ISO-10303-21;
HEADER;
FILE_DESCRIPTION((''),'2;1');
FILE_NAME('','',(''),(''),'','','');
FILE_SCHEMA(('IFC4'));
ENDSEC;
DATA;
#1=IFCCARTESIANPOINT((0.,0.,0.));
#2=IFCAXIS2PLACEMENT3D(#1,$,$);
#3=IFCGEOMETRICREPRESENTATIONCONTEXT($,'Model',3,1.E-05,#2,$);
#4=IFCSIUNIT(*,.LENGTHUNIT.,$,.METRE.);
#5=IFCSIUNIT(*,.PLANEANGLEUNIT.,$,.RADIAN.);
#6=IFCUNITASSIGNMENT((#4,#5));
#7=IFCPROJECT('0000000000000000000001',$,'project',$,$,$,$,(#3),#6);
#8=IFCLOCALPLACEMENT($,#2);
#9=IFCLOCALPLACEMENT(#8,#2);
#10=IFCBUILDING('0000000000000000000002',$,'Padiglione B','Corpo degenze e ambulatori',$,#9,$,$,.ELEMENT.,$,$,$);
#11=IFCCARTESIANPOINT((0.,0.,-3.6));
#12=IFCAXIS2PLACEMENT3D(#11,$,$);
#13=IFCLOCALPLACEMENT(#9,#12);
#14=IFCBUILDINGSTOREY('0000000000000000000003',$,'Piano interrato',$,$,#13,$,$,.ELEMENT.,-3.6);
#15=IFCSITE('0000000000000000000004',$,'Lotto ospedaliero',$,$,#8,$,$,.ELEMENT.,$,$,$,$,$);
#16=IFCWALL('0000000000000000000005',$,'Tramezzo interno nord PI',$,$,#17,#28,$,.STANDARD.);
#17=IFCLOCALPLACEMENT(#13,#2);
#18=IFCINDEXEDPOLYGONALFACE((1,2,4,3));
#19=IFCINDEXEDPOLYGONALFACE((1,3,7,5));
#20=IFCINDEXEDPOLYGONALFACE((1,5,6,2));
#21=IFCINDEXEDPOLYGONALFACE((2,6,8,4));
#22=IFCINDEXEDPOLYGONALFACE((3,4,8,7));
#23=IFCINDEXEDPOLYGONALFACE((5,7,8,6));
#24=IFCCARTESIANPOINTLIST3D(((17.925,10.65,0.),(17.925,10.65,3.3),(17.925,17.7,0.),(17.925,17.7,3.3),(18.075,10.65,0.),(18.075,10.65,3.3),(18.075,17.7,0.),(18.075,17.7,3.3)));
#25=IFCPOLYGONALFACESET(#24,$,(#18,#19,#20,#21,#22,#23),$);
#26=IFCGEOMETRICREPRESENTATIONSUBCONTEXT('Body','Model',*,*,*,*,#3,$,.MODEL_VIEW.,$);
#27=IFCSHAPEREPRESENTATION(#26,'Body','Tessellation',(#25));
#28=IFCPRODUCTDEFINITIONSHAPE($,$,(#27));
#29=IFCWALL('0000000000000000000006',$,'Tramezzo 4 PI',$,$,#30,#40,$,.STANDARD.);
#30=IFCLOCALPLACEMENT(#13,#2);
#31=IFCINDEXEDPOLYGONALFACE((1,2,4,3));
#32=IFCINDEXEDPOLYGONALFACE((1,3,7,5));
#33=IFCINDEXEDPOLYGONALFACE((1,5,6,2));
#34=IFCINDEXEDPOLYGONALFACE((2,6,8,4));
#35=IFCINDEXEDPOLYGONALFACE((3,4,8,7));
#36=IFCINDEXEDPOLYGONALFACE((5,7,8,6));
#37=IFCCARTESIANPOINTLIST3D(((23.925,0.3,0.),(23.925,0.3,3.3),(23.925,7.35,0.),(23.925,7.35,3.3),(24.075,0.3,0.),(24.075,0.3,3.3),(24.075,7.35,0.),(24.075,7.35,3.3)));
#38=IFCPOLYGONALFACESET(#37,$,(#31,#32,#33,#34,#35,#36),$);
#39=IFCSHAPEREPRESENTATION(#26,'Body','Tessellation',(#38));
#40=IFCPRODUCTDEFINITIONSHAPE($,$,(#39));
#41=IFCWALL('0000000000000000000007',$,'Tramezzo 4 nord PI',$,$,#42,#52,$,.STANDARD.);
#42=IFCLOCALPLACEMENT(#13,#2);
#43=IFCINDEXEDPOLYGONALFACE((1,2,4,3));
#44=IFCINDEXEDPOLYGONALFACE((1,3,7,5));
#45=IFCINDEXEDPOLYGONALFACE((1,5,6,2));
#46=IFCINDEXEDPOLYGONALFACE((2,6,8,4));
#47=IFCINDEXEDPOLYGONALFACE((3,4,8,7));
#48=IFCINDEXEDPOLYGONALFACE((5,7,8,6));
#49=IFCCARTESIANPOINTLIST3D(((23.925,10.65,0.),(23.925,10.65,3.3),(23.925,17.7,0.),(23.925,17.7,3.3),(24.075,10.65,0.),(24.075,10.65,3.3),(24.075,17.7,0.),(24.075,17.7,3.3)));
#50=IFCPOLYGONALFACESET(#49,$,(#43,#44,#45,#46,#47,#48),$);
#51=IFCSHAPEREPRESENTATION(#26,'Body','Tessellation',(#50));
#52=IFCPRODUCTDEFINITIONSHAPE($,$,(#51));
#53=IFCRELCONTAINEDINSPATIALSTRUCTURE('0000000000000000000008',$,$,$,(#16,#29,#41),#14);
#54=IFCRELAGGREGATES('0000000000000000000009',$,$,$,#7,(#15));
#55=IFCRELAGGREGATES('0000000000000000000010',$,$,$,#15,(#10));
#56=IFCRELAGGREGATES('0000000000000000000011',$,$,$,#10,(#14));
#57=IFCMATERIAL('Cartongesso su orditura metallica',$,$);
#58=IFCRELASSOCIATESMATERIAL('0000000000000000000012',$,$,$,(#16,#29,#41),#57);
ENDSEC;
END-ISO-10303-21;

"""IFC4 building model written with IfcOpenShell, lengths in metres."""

from ifc_helpers import new_model, si_unit, frame, frame_2d, origin, place, context, subcontext, project, spatial, rectangle, extrude, material, element, save


model = new_model("IFC4")

# Units and contexts
model_context = context("Model", 3, precision=1e-05, world=origin())
body_context = subcontext(model_context, "Body", "Model", "MODEL_VIEW")
ifc_project = project(units=[si_unit("LENGTHUNIT", "METRE"), si_unit("PLANEANGLEUNIT", "RADIAN")], contexts=[model_context])

# Site, building, storey
site_placement = place(None, origin())
site = spatial("IfcSite", under=ifc_project, at=site_placement, Name="Lotto ospedaliero", CompositionType="ELEMENT")
building_placement = place(site_placement, origin())
building = spatial("IfcBuilding", under=site, at=building_placement, Name="Padiglione B", Description="Corpo degenze e ambulatori", CompositionType="ELEMENT")
storey_placement = place(building_placement, frame((0.0, 0.0, -3.6)))
storey = spatial("IfcBuildingStorey", under=building, at=storey_placement, Name="Piano interrato", CompositionType="ELEMENT", Elevation=-3.6)

# Walls
ifc_material_1 = material(Name="Cartongesso su orditura metallica")
for number, where, name in (
    (1, (17.925, 10.65, 0.0), "Tramezzo interno nord PI"),
    (2, (23.925, 0.3, 0.0), "Tramezzo 4 PI"),
    (3, (23.925, 10.65, 0.0), "Tramezzo 4 nord PI"),
):
    element("IfcWall", number, at=place(storey_placement, frame(where)), inside=storey, material=ifc_material_1, Name=name, PredefinedType="STANDARD", context=body_context, shape_type="SweptSolid", body=[
        extrude(rectangle(XDim=0.15, YDim=7.05, at=frame_2d((0.075, 3.525))), origin(), (0.0, 0.0, 1.0), 3.3),
    ])

save(model, "model.ifc")
